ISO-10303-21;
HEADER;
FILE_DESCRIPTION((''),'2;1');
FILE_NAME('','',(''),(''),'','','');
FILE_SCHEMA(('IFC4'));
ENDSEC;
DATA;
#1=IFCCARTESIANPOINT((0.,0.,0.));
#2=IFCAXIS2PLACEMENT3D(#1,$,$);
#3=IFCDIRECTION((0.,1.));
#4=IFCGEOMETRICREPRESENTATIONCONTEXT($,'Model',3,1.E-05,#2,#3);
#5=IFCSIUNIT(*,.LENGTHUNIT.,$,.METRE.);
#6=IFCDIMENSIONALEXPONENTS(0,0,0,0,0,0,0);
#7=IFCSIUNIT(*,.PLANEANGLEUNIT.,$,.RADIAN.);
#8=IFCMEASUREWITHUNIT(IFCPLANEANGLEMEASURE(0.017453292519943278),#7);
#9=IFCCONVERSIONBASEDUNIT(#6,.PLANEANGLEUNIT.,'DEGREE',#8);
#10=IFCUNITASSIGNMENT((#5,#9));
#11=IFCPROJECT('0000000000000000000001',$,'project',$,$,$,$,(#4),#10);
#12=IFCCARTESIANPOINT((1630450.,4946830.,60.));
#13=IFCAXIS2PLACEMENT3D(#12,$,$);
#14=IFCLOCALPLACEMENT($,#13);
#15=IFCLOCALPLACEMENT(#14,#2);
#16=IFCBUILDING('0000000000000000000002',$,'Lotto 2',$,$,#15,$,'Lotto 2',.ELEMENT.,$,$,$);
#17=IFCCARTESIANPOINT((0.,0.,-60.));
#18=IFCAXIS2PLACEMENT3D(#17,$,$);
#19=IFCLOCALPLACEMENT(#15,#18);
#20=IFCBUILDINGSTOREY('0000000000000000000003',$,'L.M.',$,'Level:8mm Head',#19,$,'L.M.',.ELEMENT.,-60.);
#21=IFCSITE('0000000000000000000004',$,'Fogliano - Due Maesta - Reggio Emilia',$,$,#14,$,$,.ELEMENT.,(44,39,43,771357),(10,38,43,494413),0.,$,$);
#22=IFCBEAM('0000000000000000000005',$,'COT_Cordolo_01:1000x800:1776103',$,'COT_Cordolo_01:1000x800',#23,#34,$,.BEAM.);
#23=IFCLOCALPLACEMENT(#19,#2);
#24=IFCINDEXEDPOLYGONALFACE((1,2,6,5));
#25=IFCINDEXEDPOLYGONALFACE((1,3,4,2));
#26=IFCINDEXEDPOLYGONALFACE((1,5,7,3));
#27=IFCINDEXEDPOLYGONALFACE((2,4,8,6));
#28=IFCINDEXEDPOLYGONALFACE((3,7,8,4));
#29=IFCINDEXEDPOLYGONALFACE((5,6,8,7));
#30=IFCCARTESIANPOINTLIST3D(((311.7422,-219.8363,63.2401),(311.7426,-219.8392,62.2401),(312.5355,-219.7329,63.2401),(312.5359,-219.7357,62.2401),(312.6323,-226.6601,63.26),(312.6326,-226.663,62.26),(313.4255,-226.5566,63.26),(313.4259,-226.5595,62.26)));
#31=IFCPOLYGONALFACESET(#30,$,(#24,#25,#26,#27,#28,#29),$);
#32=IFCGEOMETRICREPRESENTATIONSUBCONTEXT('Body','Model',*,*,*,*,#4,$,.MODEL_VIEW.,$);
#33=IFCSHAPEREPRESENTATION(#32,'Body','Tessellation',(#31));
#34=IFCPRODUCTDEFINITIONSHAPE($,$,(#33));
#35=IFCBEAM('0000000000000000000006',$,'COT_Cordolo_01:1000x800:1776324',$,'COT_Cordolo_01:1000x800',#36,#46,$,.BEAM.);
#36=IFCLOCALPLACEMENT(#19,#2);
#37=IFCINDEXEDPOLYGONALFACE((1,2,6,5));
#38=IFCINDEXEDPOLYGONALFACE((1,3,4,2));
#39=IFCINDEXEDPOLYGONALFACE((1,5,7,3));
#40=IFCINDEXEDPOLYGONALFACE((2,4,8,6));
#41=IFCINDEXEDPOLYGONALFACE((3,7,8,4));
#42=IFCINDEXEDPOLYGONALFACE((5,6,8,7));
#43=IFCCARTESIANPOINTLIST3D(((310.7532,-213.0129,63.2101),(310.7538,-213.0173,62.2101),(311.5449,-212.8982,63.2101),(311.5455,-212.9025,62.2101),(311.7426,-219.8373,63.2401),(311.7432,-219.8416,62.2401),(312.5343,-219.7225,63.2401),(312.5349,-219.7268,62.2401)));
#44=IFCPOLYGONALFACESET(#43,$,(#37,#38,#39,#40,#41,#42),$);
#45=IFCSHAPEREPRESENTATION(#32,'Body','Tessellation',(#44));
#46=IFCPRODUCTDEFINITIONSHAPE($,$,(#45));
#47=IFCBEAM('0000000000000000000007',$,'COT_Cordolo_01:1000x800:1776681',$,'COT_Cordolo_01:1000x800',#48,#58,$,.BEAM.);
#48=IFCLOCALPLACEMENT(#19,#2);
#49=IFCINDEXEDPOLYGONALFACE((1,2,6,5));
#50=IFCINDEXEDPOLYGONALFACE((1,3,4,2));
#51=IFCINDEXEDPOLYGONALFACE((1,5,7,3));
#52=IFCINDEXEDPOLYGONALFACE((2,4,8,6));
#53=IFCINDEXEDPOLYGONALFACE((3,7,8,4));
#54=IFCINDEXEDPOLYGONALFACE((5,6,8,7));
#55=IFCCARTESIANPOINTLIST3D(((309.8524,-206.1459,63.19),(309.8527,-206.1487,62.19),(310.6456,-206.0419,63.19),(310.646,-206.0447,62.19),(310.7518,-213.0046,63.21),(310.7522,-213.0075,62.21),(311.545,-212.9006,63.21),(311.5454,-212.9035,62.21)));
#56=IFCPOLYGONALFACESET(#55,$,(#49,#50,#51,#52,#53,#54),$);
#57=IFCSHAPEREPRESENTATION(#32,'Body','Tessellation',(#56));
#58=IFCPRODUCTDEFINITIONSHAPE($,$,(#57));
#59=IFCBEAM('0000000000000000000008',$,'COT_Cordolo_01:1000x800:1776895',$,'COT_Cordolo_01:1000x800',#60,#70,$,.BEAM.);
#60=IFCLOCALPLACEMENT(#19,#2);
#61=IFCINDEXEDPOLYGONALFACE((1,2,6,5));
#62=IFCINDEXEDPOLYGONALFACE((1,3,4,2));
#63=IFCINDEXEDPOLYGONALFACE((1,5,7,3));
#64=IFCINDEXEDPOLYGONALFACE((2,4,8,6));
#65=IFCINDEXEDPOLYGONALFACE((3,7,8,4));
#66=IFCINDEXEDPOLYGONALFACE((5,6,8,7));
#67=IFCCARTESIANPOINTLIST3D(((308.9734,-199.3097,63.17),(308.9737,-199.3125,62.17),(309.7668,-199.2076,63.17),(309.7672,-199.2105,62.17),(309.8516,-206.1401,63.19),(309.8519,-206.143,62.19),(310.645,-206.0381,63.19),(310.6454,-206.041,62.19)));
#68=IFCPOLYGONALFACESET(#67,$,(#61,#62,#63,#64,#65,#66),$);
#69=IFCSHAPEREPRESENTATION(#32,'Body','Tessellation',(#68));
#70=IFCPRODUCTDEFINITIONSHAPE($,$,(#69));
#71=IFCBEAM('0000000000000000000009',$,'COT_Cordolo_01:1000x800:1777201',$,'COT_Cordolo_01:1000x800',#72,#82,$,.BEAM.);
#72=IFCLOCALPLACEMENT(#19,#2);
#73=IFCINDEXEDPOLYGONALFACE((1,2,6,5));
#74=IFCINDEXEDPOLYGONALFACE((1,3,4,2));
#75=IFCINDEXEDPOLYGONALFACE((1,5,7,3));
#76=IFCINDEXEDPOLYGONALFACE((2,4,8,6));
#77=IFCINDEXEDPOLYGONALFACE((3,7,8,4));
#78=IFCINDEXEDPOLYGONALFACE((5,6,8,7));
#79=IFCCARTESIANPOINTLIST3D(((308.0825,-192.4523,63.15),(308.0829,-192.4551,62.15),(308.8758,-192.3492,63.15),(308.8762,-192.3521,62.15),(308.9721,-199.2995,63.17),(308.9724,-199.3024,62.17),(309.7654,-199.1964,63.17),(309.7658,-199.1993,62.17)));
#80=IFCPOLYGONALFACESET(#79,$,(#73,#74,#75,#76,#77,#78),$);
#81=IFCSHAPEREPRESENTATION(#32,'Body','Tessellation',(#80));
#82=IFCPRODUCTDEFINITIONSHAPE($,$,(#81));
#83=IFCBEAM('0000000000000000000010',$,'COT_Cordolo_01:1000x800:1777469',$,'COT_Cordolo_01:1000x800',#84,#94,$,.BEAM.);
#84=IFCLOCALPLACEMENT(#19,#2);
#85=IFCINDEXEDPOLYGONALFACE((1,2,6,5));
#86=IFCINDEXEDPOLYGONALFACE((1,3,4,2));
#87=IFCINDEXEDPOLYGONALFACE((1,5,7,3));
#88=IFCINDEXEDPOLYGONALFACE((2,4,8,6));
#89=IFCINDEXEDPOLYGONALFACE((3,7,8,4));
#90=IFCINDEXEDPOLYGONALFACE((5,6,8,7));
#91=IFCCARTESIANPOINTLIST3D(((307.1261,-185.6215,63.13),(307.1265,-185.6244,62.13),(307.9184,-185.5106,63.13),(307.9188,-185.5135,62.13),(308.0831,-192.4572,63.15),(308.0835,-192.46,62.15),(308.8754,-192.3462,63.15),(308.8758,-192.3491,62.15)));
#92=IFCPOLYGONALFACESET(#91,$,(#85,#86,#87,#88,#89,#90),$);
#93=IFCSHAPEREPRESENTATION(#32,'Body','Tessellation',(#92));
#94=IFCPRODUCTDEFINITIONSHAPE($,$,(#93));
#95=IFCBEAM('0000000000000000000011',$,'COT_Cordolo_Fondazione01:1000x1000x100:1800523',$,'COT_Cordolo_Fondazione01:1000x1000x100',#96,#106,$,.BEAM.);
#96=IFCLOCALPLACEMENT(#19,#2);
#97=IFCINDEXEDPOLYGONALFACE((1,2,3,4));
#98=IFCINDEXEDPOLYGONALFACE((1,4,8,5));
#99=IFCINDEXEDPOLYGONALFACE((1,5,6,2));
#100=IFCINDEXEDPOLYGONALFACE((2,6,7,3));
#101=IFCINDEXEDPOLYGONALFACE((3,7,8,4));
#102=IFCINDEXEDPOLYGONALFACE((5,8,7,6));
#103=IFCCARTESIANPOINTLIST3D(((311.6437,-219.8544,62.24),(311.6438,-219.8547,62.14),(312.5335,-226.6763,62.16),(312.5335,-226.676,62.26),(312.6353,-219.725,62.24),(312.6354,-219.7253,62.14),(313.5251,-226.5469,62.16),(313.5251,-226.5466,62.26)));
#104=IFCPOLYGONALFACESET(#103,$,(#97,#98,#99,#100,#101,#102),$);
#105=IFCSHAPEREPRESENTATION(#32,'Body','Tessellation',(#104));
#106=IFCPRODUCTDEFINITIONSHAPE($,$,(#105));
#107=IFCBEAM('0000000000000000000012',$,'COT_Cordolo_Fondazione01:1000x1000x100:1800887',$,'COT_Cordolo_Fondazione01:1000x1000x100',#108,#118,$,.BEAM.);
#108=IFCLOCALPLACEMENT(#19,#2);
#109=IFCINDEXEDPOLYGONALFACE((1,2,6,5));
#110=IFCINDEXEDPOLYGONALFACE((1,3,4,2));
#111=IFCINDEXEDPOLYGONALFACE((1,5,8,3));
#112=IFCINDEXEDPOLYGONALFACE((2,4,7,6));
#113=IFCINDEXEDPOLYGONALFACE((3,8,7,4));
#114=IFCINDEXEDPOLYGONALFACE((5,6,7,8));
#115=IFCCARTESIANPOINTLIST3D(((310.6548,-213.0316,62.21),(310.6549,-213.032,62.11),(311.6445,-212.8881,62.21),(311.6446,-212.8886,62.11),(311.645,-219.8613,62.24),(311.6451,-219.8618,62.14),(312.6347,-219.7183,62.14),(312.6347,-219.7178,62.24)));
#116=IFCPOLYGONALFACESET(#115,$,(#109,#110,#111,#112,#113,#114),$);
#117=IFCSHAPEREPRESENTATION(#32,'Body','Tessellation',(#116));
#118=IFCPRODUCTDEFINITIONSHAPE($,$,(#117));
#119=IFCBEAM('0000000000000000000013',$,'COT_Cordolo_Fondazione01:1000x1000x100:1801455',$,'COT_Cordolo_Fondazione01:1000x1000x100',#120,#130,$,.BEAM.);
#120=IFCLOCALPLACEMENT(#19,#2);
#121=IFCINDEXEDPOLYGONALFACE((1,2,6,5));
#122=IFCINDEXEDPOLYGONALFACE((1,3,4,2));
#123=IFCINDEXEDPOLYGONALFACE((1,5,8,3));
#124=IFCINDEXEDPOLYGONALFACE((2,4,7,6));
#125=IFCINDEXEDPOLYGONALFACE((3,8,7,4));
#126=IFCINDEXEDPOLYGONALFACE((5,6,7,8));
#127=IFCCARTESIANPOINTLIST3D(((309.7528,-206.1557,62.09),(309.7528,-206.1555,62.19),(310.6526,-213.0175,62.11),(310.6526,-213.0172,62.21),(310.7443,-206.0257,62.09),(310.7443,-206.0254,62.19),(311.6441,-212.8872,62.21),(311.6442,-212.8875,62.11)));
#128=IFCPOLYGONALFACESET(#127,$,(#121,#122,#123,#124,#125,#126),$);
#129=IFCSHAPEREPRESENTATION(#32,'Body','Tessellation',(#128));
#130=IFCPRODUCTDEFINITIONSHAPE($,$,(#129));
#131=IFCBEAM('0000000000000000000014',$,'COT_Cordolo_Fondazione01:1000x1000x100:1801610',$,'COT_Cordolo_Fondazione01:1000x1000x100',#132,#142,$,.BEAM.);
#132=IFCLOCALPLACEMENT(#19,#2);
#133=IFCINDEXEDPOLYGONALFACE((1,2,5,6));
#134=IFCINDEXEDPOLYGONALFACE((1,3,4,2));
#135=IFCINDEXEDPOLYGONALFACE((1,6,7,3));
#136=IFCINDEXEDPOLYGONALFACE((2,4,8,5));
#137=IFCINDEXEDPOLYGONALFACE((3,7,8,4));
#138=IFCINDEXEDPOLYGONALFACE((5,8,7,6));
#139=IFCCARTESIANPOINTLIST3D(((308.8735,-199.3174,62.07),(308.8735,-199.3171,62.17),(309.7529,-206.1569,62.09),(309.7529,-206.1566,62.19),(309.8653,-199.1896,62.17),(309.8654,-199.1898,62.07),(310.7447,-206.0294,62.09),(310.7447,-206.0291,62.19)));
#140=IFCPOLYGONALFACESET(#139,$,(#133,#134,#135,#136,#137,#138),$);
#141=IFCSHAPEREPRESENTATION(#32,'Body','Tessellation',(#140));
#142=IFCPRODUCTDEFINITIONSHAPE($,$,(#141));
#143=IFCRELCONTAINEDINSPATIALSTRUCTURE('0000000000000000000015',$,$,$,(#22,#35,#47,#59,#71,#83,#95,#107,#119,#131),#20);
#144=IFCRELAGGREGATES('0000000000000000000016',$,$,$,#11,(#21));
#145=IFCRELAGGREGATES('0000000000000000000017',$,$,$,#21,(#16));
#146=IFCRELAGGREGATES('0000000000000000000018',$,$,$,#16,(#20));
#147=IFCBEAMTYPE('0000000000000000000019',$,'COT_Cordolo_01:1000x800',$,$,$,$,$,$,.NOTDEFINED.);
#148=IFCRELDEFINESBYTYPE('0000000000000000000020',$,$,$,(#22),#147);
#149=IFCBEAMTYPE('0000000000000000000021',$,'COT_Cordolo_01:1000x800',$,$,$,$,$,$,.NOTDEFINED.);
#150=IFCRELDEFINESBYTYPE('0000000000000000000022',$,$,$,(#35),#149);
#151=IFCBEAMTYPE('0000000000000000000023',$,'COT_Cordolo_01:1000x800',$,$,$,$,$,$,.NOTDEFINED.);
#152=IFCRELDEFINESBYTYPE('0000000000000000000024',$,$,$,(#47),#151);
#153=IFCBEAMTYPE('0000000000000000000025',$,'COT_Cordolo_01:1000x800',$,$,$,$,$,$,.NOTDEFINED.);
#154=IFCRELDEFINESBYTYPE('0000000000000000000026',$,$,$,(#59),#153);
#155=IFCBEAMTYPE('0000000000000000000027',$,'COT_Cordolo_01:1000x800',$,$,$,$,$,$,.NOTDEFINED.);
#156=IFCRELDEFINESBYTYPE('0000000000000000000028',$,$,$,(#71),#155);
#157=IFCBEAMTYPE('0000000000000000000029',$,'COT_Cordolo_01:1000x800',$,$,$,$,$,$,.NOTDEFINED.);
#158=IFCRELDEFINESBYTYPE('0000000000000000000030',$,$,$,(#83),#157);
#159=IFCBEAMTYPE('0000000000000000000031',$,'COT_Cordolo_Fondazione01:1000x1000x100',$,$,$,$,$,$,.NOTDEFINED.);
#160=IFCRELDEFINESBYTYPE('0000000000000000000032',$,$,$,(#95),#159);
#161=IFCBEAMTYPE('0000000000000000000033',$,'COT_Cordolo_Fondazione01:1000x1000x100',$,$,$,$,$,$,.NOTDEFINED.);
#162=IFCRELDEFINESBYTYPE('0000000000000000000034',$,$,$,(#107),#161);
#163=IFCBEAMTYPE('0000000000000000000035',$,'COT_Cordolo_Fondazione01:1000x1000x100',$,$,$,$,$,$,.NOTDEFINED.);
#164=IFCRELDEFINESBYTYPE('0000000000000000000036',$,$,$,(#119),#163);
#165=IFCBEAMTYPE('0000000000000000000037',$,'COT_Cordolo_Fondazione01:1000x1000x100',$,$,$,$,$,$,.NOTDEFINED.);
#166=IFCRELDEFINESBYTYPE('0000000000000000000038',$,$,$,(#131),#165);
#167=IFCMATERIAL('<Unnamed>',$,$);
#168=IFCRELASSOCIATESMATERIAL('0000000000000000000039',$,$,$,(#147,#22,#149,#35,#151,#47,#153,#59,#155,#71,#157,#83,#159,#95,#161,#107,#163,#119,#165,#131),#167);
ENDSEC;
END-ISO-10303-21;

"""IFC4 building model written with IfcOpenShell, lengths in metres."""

from ifc_helpers import new_model, entity, si_unit, converted_unit, direction, frame, origin, place, context, subcontext, project, spatial, indexed_curve, outline, extrude, source, transform, mapped, material, type_object, type_shapes, element, save


model = new_model("IFC4")

# Units and contexts
model_context = context("Model", 3, precision=1e-05, world=origin(), true_north=direction((0.0, 1.0)))
body_context = subcontext(model_context, "Body", "Model", "MODEL_VIEW")
ifc_project = project(units=[si_unit("LENGTHUNIT", "METRE"), converted_unit("PLANEANGLEUNIT", "DEGREE", entity("IfcPlaneAngleMeasure", 0.017453292519943278), si_unit("PLANEANGLEUNIT", "RADIAN"), dimensions=[0, 0, 0, 0, 0, 0, 0])], contexts=[model_context])

# Site, building, storey
site_placement = place(None, frame((1630450.0, 4946830.0, 60.0)))
site = spatial("IfcSite", under=ifc_project, at=site_placement, Name="Fogliano - Due Maesta - Reggio Emilia", CompositionType="ELEMENT", RefLatitude=(44, 39, 43, 771357), RefLongitude=(10, 38, 43, 494413), RefElevation=0.0)
building_placement = place(site_placement, origin())
building = spatial("IfcBuilding", under=site, at=building_placement, Name="Lotto 2", LongName="Lotto 2", CompositionType="ELEMENT")
storey_placement = place(building_placement, frame((0.0, 0.0, -60.0)))
storey = spatial("IfcBuildingStorey", under=building, at=storey_placement, Name="L.M.", ObjectType="Level:8mm Head", LongName="L.M.", CompositionType="ELEMENT", Elevation=-60.0)

# Beams
ifc_material_1 = material(Name="<Unnamed>")
beam_type_1 = type_object("IfcBeamType", Name="COT_Cordolo_01:1000x800", PredefinedType="NOTDEFINED", material=ifc_material_1)
shared_shape_1 = source(origin(), body_context, "Body", "SweptSolid", [
    extrude(outline(indexed_curve([(-3.4408, -0.4), (3.4408, -0.4), (3.4408, 0.4), (-3.4408, 0.4), (-3.4408, -0.4)], self_intersect=False)), frame((-0.0092, 0.0, -0.5), z_axis=(0.0, 0.0, 1.0), x_axis=(-1.0, 0.0, 0.0)), (0.0, 0.0, 1.0), 1.0),
])
type_shapes(beam_type_1, [shared_shape_1])
beam_1_placement = place(storey_placement, frame((312.5829, -223.1888, 62.75), z_axis=(-0.000375, 0.002874, 0.999996), x_axis=(-0.129339, 0.991596, -0.002899)))
element("IfcBeam", 1, at=beam_1_placement, inside=storey, type_object=beam_type_1, material=ifc_material_1, Name="COT_Cordolo_01:1000x800:1776103", ObjectType="COT_Cordolo_01:1000x800", PredefinedType="BEAM", context=body_context, shape_type="MappedRepresentation", body=[
    mapped(shared_shape_1, transform((0.0, 0.0, 0.0), scale=1.0)),
])
beam_type_2 = type_object("IfcBeamType", Name="COT_Cordolo_01:1000x800", PredefinedType="NOTDEFINED", material=ifc_material_1)
shared_shape_2 = source(origin(), body_context, "Body", "SweptSolid", [
    extrude(outline(indexed_curve([(-3.4479, -0.4), (3.4479, -0.4), (3.4479, 0.4), (-3.4479, 0.4), (-3.4479, -0.4)], self_intersect=False)), frame((-0.0159, 0.0, -0.5), z_axis=(0.0, 0.0, 1.0), x_axis=(-1.0, 0.0, 0.0)), (0.0, 0.0, 1.0), 1.0),
])
type_shapes(beam_type_2, [shared_shape_2])
beam_2_placement = place(storey_placement, frame((311.6418, -216.3541, 62.725), z_axis=(-0.000624, 0.004303, 0.999991), x_axis=(-0.143477, 0.989644, -0.004348)))
element("IfcBeam", 2, at=beam_2_placement, inside=storey, type_object=beam_type_2, material=ifc_material_1, Name="COT_Cordolo_01:1000x800:1776324", ObjectType="COT_Cordolo_01:1000x800", PredefinedType="BEAM", context=body_context, shape_type="MappedRepresentation", body=[
    mapped(shared_shape_2, transform((0.0, 0.0, 0.0), scale=1.0)),
])
beam_type_3 = type_object("IfcBeamType", Name="COT_Cordolo_01:1000x800", PredefinedType="NOTDEFINED", material=ifc_material_1)
shared_shape_3 = source(origin(), body_context, "Body", "SweptSolid", [
    extrude(outline(indexed_curve([(-3.4588, -0.4), (3.4588, -0.4), (3.4588, 0.4), (-3.4588, 0.4), (-3.4588, -0.4)], self_intersect=False)), frame((-0.0064, 0.0, -0.5), z_axis=(0.0, 0.0, 1.0), x_axis=(-1.0, 0.0, 0.0)), (0.0, 0.0, 1.0), 1.0),
])
type_shapes(beam_type_3, [shared_shape_3])
beam_3_placement = place(storey_placement, frame((310.698, -209.5183, 62.7), z_axis=(-0.000377, 0.002874, 0.999996), x_axis=(-0.130025, 0.991507, -0.002899)))
element("IfcBeam", 3, at=beam_3_placement, inside=storey, type_object=beam_type_3, material=ifc_material_1, Name="COT_Cordolo_01:1000x800:1776681", ObjectType="COT_Cordolo_01:1000x800", PredefinedType="BEAM", context=body_context, shape_type="MappedRepresentation", body=[
    mapped(shared_shape_3, transform((0.0, 0.0, 0.0), scale=1.0)),
])
beam_type_4 = type_object("IfcBeamType", Name="COT_Cordolo_01:1000x800", PredefinedType="NOTDEFINED", material=ifc_material_1)
shared_shape_4 = source(origin(), body_context, "Body", "SweptSolid", [
    extrude(outline(indexed_curve([(-3.4434, -0.4), (3.4434, -0.4), (3.4434, 0.4), (-3.4434, 0.4), (-3.4434, -0.4)], self_intersect=False)), frame((-0.0066, 0.0, -0.5), z_axis=(0.0, 0.0, 1.0), x_axis=(-1.0, 0.0, 0.0)), (0.0, 0.0, 1.0), 1.0),
])
type_shapes(beam_type_4, [shared_shape_4])
beam_4_placement = place(storey_placement, frame((309.8085, -202.6688, 62.68), z_axis=(-0.000369, 0.002868, 0.999996), x_axis=(-0.127521, 0.991832, -0.002892)))
element("IfcBeam", 4, at=beam_4_placement, inside=storey, type_object=beam_type_4, material=ifc_material_1, Name="COT_Cordolo_01:1000x800:1776895", ObjectType="COT_Cordolo_01:1000x800", PredefinedType="BEAM", context=body_context, shape_type="MappedRepresentation", body=[
    mapped(shared_shape_4, transform((0.0, 0.0, 0.0), scale=1.0)),
])
beam_type_5 = type_object("IfcBeamType", Name="COT_Cordolo_01:1000x800", PredefinedType="NOTDEFINED", material=ifc_material_1)
shared_shape_5 = source(origin(), body_context, "Body", "SweptSolid", [
    extrude(outline(indexed_curve([(-3.4524, -0.4), (3.4524, -0.4), (3.4524, 0.4), (-3.4524, 0.4), (-3.4524, -0.4)], self_intersect=False)), frame((0.0, 0.0, -0.5), z_axis=(0.0, 0.0, 1.0), x_axis=(-1.0, 0.0, 0.0)), (0.0, 0.0, 1.0), 1.0),
])
type_shapes(beam_type_5, [shared_shape_5])
beam_5_placement = place(storey_placement, frame((308.9241, -195.8257, 62.66), z_axis=(-0.000373, 0.002874, 0.999996), x_axis=(-0.128833, 0.991662, -0.002899)))
element("IfcBeam", 5, at=beam_5_placement, inside=storey, type_object=beam_type_5, material=ifc_material_1, Name="COT_Cordolo_01:1000x800:1777201", ObjectType="COT_Cordolo_01:1000x800", PredefinedType="BEAM", context=body_context, shape_type="MappedRepresentation", body=[
    mapped(shared_shape_5, transform((0.0, 0.0, 0.0), scale=1.0)),
])
beam_type_6 = type_object("IfcBeamType", Name="COT_Cordolo_01:1000x800", PredefinedType="NOTDEFINED", material=ifc_material_1)
shared_shape_6 = source(origin(), body_context, "Body", "SweptSolid", [
    extrude(outline(indexed_curve([(-3.4512, -0.4), (3.4512, -0.4), (3.4512, 0.4), (-3.4512, 0.4), (-3.4512, -0.4)], self_intersect=False)), frame((0.0012, 0.0, -0.5), z_axis=(0.0, 0.0, 1.0), x_axis=(-1.0, 0.0, 0.0)), (0.0, 0.0, 1.0), 1.0),
])
type_shapes(beam_type_6, [shared_shape_6])
beam_6_placement = place(storey_placement, frame((308.0011, -188.9865, 62.64), z_axis=(-0.000402, 0.002871, 0.999996), x_axis=(-0.138647, 0.990338, -0.002899)))
element("IfcBeam", 6, at=beam_6_placement, inside=storey, type_object=beam_type_6, material=ifc_material_1, Name="COT_Cordolo_01:1000x800:1777469", ObjectType="COT_Cordolo_01:1000x800", PredefinedType="BEAM", context=body_context, shape_type="MappedRepresentation", body=[
    mapped(shared_shape_6, transform((0.0, 0.0, 0.0), scale=1.0)),
])
beam_type_7 = type_object("IfcBeamType", Name="COT_Cordolo_Fondazione01:1000x1000x100", PredefinedType="NOTDEFINED", material=ifc_material_1)
shared_shape_7 = source(origin(), body_context, "Body", "SweptSolid", [
    extrude(outline(indexed_curve([(-3.4397, -0.5), (3.4397, -0.5), (3.4397, 0.5), (-3.4397, 0.5), (-3.4397, -0.5)], self_intersect=False)), frame((0.0003, 0.0, -0.05), z_axis=(0.0, 0.0, 1.0), x_axis=(-1.0, 0.0, 0.0)), (0.0, 0.0, 1.0), 0.1),
])
type_shapes(beam_type_7, [shared_shape_7])
beam_7_placement = place(storey_placement, frame((312.5845, -223.201, 62.2), z_axis=(-0.000376, 0.002883, 0.999996), x_axis=(-0.129339, 0.991596, -0.002907)))
element("IfcBeam", 7, at=beam_7_placement, inside=storey, type_object=beam_type_7, material=ifc_material_1, Name="COT_Cordolo_Fondazione01:1000x1000x100:1800523", ObjectType="COT_Cordolo_Fondazione01:1000x1000x100", PredefinedType="BEAM", context=body_context, shape_type="MappedRepresentation", body=[
    mapped(shared_shape_7, transform((0.0, 0.0, 0.0), scale=1.0)),
])
beam_type_8 = type_object("IfcBeamType", Name="COT_Cordolo_Fondazione01:1000x1000x100", PredefinedType="NOTDEFINED", material=ifc_material_1)
shared_shape_8 = source(origin(), body_context, "Body", "SweptSolid", [
    extrude(outline(indexed_curve([(-3.4506, -0.5), (3.4506, -0.5), (3.4506, 0.5), (-3.4506, 0.5), (-3.4506, -0.5)], self_intersect=False)), frame((-0.0013, 0.0, -0.05), z_axis=(0.0, 0.0, 1.0), x_axis=(-1.0, 0.0, 0.0)), (0.0, 0.0, 1.0), 0.1),
])
type_shapes(beam_type_8, [shared_shape_8])
beam_8_placement = place(storey_placement, frame((311.6446, -216.3736, 62.175), z_axis=(-0.000623, 0.0043, 0.999991), x_axis=(-0.143477, 0.989644, -0.004345)))
element("IfcBeam", 8, at=beam_8_placement, inside=storey, type_object=beam_type_8, material=ifc_material_1, Name="COT_Cordolo_Fondazione01:1000x1000x100:1800887", ObjectType="COT_Cordolo_Fondazione01:1000x1000x100", PredefinedType="BEAM", context=body_context, shape_type="MappedRepresentation", body=[
    mapped(shared_shape_8, transform((0.0, 0.0, 0.0), scale=1.0)),
])
beam_type_9 = type_object("IfcBeamType", Name="COT_Cordolo_Fondazione01:1000x1000x100", PredefinedType="NOTDEFINED", material=ifc_material_1)
shared_shape_9 = source(origin(), body_context, "Body", "SweptSolid", [
    extrude(outline(indexed_curve([(-3.4603, -0.5), (3.4603, -0.5), (3.4603, 0.5), (-3.4603, 0.5), (-3.4603, -0.5)], self_intersect=False)), frame((0.0084, 0.0, -0.05), z_axis=(0.0, 0.0, 1.0), x_axis=(-1.0, 0.0, 0.0)), (0.0, 0.0, 1.0), 0.1),
])
type_shapes(beam_type_9, [shared_shape_9])
beam_9_placement = place(storey_placement, frame((310.6995, -209.5297, 62.15), z_axis=(-0.000377, 0.002872, 0.999996), x_axis=(-0.130025, 0.991507, -0.002896)))
element("IfcBeam", 9, at=beam_9_placement, inside=storey, type_object=beam_type_9, material=ifc_material_1, Name="COT_Cordolo_Fondazione01:1000x1000x100:1801455", ObjectType="COT_Cordolo_Fondazione01:1000x1000x100", PredefinedType="BEAM", context=body_context, shape_type="MappedRepresentation", body=[
    mapped(shared_shape_9, transform((0.0, 0.0, 0.0), scale=1.0)),
])
beam_type_10 = type_object("IfcBeamType", Name="COT_Cordolo_Fondazione01:1000x1000x100", PredefinedType="NOTDEFINED", material=ifc_material_1)
shared_shape_10 = source(origin(), body_context, "Body", "SweptSolid", [
    extrude(outline(indexed_curve([(-3.4479, -0.5), (3.4479, -0.5), (3.4479, 0.5), (-3.4479, 0.5), (-3.4479, -0.5)], self_intersect=False)), frame((-0.0015, 0.0, -0.05), z_axis=(0.0, 0.0, 1.0), x_axis=(-1.0, 0.0, 0.0)), (0.0, 0.0, 1.0), 0.1),
])
type_shapes(beam_type_10, [shared_shape_10])
beam_10_placement = place(storey_placement, frame((309.8089, -202.6718, 62.13), z_axis=(-0.00037, 0.002875, 0.999996), x_axis=(-0.127521, 0.991832, -0.002899)))
element("IfcBeam", 10, at=beam_10_placement, inside=storey, type_object=beam_type_10, material=ifc_material_1, Name="COT_Cordolo_Fondazione01:1000x1000x100:1801610", ObjectType="COT_Cordolo_Fondazione01:1000x1000x100", PredefinedType="BEAM", context=body_context, shape_type="MappedRepresentation", body=[
    mapped(shared_shape_10, transform((0.0, 0.0, 0.0), scale=1.0)),
])

save(model, "model.ifc")
